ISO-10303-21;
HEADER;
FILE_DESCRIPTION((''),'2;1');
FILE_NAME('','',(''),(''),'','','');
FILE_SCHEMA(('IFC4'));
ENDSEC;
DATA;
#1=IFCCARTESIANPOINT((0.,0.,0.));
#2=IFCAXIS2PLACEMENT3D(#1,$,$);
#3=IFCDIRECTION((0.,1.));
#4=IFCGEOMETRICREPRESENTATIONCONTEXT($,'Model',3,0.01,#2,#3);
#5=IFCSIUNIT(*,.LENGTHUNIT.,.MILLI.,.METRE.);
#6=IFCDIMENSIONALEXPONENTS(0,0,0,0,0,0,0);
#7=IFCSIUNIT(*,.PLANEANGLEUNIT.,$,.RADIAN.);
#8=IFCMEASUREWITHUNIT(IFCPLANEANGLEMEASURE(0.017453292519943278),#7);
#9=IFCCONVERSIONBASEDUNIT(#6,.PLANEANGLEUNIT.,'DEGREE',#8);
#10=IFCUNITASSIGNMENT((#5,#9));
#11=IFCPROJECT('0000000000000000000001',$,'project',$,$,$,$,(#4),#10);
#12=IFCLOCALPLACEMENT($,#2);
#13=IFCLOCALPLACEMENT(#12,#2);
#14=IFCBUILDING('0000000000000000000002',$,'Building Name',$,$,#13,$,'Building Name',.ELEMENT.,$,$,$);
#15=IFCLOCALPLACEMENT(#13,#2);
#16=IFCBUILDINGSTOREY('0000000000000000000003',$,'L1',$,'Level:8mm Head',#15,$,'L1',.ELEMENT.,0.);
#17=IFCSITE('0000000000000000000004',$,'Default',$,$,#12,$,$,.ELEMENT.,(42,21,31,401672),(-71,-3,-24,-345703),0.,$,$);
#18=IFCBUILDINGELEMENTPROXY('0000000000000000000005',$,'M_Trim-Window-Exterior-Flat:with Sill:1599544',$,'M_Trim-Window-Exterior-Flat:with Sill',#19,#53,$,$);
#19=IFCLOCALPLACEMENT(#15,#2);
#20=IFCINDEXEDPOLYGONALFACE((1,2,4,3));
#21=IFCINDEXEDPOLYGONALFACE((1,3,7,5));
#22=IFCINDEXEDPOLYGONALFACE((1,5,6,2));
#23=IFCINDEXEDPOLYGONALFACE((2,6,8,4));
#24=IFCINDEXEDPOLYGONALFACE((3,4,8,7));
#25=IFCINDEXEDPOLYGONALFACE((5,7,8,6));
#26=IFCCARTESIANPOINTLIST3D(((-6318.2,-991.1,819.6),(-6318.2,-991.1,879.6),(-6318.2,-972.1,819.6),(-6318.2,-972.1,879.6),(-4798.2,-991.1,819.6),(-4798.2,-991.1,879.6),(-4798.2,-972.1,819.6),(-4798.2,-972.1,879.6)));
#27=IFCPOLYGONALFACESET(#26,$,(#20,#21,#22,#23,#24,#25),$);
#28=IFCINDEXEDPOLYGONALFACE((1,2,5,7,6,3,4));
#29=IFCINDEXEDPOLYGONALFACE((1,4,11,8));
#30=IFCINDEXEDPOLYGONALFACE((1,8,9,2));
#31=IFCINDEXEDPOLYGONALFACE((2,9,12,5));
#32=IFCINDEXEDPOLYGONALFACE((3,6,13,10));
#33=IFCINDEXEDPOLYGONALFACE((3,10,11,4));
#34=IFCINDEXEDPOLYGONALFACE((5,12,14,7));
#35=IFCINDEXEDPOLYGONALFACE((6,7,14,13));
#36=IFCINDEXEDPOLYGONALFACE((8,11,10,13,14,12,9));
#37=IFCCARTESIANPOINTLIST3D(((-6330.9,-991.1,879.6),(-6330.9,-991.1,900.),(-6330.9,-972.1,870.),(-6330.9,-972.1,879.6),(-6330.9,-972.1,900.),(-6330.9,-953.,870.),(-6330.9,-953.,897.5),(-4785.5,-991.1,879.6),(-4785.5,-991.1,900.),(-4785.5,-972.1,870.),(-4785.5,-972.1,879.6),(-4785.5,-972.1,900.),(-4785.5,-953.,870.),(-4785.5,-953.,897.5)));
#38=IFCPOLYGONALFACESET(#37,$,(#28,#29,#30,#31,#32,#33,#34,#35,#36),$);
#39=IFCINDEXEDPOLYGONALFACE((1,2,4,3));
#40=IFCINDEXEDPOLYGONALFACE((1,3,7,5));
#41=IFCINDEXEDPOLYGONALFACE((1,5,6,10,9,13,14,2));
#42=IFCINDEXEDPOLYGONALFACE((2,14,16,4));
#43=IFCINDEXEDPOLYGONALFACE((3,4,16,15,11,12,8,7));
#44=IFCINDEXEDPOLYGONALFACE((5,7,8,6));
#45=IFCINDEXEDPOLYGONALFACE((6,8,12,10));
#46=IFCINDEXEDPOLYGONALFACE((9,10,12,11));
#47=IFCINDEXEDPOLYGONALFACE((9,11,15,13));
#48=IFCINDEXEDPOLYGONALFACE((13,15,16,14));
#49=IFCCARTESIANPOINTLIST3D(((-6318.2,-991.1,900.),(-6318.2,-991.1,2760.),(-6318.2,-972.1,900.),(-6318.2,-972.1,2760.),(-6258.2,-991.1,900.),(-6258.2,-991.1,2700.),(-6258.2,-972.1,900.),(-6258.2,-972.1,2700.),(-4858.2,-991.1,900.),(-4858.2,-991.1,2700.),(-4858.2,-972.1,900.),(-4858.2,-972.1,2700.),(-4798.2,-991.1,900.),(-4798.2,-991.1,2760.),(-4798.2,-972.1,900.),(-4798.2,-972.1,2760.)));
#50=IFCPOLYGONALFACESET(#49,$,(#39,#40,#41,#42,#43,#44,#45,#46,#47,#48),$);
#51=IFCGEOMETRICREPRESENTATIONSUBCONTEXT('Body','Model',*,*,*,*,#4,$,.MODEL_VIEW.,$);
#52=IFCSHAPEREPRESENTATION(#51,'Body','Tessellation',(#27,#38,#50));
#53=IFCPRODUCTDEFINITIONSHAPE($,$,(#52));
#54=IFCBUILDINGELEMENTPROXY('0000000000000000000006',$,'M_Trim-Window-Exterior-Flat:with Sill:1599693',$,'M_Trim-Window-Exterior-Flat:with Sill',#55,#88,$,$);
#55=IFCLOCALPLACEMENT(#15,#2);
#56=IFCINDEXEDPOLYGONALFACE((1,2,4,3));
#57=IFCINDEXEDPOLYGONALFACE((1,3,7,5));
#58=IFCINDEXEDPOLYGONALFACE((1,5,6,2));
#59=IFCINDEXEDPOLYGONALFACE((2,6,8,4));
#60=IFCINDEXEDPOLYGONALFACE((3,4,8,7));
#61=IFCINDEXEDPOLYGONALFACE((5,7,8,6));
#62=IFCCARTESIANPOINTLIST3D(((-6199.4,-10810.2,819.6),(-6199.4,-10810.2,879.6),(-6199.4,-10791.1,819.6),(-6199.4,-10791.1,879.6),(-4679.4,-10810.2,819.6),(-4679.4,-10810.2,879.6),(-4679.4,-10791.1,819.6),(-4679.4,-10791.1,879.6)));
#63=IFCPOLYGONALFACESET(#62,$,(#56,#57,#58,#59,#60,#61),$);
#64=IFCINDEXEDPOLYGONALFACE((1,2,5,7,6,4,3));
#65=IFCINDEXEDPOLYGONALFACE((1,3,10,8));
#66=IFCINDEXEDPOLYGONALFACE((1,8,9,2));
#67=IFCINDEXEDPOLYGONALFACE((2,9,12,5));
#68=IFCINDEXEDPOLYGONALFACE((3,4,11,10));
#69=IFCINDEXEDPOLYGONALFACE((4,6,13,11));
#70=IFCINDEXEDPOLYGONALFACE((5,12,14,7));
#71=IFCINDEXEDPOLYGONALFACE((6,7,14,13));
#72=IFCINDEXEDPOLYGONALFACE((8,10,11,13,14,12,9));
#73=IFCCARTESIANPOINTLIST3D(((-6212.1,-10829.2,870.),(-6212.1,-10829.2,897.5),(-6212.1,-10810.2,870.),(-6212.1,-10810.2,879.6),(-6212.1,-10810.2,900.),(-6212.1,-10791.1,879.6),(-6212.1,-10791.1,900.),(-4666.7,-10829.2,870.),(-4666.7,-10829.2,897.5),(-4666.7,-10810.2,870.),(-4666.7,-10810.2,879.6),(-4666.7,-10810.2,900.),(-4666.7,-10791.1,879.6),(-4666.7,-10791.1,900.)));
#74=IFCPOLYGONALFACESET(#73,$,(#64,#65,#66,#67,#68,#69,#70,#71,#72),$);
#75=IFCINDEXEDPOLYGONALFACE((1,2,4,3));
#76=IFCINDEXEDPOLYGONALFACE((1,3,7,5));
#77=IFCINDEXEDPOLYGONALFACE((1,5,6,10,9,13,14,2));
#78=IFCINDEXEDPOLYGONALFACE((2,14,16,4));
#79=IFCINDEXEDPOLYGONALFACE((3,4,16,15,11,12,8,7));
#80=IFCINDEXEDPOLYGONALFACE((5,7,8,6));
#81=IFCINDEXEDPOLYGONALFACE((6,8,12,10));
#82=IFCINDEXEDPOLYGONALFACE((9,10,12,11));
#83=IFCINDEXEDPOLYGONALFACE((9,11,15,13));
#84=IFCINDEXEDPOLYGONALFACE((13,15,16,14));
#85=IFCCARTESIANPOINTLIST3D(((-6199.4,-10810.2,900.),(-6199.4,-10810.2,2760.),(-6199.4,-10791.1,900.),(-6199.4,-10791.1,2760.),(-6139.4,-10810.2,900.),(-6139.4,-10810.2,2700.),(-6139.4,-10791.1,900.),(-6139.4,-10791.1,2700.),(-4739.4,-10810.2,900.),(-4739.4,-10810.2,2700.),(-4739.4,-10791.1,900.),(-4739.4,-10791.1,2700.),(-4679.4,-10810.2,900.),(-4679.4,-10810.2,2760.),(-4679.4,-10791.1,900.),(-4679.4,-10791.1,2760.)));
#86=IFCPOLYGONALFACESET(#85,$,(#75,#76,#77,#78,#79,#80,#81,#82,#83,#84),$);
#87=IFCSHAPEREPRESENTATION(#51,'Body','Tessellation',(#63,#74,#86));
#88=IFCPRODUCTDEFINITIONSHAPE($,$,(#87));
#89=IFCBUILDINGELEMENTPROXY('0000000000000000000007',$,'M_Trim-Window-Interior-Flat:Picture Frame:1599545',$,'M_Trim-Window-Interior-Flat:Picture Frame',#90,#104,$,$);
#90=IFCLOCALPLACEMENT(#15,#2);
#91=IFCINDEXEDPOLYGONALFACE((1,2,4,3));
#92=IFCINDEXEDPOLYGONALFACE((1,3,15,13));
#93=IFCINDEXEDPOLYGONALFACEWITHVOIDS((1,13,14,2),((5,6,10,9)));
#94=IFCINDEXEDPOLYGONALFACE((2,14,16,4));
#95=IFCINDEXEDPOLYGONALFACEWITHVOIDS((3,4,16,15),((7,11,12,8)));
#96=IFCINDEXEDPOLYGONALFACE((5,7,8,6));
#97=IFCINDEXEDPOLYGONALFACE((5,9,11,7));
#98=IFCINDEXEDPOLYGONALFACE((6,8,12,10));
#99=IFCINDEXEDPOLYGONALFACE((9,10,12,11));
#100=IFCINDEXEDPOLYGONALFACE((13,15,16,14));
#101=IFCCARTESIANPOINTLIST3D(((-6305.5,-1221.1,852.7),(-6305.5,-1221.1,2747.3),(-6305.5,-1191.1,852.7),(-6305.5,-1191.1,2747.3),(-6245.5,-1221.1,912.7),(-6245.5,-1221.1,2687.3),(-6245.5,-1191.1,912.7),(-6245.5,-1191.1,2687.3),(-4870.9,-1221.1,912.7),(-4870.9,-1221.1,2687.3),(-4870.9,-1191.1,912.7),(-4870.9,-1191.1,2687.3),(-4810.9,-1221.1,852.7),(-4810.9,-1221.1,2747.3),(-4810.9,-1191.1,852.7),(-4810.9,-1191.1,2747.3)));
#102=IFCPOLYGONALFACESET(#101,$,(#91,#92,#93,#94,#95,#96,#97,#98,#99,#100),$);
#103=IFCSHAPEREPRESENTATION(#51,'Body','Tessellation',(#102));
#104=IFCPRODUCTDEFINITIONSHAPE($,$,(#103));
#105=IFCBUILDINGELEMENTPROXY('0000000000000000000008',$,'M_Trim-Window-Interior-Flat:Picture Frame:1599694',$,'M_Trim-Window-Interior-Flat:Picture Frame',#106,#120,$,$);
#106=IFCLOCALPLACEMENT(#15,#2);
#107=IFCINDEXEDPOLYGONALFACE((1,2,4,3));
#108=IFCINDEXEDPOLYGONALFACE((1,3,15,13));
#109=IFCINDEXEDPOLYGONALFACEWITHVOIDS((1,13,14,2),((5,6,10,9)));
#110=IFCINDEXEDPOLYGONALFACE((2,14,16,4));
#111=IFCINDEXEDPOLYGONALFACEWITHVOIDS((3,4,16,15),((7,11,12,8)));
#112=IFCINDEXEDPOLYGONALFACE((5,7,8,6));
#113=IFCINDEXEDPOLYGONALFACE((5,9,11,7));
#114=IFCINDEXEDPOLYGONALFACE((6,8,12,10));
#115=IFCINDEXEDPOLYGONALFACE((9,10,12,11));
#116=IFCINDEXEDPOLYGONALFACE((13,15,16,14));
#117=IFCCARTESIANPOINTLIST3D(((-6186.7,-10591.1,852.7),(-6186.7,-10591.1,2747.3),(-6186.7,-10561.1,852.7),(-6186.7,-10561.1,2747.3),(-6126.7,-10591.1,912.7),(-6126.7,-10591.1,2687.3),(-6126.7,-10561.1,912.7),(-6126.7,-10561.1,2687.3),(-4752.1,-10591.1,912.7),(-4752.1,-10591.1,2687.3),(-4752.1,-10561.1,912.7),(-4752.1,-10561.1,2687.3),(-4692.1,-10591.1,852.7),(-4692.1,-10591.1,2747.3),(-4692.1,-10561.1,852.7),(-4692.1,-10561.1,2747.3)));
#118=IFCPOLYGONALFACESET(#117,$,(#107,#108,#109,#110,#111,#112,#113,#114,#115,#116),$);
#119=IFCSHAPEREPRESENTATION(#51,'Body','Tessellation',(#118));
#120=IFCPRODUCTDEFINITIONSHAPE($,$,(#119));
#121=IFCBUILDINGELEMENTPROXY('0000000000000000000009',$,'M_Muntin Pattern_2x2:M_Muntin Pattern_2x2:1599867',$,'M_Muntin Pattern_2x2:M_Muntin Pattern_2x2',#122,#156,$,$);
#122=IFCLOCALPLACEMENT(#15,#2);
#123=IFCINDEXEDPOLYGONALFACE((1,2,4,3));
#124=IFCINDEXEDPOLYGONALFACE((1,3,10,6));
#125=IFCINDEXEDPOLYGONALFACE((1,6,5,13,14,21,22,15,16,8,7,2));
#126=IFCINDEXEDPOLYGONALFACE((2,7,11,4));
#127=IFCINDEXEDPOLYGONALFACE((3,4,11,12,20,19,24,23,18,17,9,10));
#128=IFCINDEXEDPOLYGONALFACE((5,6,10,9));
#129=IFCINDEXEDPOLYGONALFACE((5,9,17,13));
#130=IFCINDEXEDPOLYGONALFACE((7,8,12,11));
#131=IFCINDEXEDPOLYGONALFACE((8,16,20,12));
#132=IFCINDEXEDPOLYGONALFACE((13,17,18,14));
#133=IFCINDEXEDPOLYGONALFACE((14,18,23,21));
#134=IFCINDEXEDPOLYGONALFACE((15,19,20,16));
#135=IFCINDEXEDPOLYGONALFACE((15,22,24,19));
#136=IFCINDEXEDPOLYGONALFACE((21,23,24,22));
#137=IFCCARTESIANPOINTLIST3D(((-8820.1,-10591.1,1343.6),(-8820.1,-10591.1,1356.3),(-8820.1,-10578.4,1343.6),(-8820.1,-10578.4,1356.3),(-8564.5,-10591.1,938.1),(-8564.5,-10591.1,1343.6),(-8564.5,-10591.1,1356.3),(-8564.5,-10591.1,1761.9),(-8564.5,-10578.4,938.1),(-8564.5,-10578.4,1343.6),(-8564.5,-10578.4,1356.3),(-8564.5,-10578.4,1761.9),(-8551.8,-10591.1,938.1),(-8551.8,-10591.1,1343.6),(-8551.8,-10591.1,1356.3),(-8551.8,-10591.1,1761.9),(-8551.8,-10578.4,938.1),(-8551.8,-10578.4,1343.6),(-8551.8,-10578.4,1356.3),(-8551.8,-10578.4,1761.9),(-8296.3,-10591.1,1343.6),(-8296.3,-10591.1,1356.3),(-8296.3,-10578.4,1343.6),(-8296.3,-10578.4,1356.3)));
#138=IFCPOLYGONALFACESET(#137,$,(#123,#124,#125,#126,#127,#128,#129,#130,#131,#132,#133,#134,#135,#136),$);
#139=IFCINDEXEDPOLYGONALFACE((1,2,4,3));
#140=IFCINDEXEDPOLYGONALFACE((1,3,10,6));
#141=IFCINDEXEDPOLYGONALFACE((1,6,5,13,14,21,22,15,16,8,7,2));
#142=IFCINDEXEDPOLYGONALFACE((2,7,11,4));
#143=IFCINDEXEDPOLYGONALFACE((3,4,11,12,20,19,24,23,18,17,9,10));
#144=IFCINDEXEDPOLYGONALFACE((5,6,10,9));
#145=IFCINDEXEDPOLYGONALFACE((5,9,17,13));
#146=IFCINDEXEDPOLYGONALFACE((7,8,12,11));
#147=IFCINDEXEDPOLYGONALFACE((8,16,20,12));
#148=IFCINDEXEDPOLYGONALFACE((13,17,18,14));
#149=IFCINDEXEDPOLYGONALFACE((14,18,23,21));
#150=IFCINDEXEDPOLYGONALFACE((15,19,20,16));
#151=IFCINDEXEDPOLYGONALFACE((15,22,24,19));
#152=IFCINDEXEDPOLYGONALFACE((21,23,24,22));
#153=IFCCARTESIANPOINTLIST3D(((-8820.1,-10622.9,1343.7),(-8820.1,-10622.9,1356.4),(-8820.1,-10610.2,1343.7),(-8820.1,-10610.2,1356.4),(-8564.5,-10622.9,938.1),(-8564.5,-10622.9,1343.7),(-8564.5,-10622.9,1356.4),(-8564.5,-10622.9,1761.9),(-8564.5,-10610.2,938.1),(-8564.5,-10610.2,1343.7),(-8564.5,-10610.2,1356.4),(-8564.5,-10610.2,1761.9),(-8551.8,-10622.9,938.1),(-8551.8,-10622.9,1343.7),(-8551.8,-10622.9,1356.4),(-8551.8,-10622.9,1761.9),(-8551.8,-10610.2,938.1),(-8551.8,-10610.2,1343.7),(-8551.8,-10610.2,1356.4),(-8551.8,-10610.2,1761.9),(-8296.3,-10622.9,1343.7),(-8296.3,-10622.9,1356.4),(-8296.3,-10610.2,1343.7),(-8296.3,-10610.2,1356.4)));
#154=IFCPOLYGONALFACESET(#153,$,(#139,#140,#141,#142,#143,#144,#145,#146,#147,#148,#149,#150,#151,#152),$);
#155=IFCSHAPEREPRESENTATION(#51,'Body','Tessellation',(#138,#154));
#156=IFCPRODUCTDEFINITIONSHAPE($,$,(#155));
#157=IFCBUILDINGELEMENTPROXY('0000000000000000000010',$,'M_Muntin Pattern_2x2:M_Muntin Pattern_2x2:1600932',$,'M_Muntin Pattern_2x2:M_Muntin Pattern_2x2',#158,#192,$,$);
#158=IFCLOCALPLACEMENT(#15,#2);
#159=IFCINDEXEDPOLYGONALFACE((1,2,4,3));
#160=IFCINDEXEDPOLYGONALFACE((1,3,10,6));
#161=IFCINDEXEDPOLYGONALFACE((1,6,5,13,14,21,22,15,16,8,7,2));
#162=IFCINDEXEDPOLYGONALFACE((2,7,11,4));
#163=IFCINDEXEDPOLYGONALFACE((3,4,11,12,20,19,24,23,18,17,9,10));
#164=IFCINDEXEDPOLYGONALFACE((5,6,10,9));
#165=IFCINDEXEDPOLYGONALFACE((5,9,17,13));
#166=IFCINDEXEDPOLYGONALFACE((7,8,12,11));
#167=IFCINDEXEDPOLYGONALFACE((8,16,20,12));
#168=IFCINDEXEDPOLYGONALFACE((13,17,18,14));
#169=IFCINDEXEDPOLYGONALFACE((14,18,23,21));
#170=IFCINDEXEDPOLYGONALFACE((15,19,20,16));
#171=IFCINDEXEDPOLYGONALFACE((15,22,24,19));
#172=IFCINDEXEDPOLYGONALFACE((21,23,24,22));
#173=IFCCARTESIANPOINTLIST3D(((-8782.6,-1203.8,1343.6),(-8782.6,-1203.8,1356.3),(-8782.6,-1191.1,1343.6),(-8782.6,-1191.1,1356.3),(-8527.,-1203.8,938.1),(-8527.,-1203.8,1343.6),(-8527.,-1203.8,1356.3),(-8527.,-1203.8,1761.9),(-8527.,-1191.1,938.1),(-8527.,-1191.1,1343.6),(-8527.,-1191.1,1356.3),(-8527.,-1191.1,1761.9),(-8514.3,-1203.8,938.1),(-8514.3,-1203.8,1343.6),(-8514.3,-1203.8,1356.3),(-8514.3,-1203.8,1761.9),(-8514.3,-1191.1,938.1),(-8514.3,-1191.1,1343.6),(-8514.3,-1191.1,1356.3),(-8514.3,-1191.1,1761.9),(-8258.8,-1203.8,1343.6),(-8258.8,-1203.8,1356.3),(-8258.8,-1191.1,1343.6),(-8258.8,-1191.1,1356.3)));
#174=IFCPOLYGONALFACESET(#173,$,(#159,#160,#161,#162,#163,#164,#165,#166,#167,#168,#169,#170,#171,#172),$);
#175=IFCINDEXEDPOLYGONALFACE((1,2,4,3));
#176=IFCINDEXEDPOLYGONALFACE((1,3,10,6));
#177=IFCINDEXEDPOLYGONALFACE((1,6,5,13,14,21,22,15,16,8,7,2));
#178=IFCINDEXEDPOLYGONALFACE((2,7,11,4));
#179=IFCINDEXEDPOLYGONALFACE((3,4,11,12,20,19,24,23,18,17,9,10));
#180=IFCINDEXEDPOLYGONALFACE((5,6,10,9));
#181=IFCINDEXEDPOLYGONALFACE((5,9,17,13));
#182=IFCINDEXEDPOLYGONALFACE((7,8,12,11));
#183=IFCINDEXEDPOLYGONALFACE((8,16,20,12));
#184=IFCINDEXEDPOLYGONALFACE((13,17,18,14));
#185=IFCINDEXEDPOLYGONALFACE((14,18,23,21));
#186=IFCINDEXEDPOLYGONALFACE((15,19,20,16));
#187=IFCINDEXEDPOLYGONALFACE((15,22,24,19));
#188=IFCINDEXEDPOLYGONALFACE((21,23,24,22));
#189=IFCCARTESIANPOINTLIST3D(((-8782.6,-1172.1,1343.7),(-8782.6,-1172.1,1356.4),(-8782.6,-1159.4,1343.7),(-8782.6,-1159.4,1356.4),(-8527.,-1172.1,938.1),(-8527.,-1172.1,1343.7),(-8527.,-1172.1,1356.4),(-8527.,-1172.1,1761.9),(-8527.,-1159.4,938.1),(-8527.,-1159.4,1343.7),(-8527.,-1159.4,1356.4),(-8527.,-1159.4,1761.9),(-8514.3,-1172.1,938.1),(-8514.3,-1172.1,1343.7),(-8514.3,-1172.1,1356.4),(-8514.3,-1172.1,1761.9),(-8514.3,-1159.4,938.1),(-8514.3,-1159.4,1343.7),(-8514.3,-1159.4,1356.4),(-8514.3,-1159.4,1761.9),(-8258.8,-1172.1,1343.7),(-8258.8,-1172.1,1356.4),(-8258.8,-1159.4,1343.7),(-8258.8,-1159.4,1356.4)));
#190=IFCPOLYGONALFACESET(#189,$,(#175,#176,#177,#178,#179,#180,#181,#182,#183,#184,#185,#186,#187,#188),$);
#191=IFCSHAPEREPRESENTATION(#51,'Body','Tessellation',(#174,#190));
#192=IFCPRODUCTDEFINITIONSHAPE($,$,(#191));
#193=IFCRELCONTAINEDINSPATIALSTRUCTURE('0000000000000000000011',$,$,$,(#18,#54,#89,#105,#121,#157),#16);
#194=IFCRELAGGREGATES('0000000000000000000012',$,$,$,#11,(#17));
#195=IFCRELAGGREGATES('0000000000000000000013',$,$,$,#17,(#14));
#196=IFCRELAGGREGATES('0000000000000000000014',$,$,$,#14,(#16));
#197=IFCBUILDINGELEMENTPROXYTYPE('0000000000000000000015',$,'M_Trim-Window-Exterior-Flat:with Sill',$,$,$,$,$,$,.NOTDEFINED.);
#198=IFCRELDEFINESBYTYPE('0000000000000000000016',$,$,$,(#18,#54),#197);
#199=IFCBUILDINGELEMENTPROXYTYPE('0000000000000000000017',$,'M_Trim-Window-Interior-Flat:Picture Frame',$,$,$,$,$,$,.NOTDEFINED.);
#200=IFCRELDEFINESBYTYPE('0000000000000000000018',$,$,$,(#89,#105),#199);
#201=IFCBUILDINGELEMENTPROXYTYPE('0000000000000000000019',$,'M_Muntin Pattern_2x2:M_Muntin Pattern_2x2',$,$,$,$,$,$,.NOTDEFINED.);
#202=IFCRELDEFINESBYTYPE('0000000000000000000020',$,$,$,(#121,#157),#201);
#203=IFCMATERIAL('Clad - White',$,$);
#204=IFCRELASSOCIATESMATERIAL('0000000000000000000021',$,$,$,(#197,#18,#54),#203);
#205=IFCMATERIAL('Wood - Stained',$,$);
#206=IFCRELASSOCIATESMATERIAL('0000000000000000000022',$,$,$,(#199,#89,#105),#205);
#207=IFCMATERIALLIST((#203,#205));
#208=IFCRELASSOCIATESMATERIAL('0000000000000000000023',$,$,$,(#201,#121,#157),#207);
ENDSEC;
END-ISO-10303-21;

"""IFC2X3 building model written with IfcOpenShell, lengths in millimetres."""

from ifc_helpers import new_model, entity, si_unit, converted_unit, direction, frame, frame_2d, origin, place, context, subcontext, project, spatial, polyline, rectangle, outline, extrude, source, transform, mapped, material, material_list, type_object, type_shapes, element, save


model = new_model("IFC2X3")

# Units and contexts
model_context = context("Model", 3, precision=0.01, world=origin(), true_north=direction((0.0, 1.0)))
body_context = subcontext(model_context, "Body", "Model", "MODEL_VIEW")
ifc_project = project(units=[si_unit("LENGTHUNIT", "METRE", prefix="MILLI"), converted_unit("PLANEANGLEUNIT", "DEGREE", entity("IfcPlaneAngleMeasure", 0.017453292519943278), si_unit("PLANEANGLEUNIT", "RADIAN"), dimensions=[0, 0, 0, 0, 0, 0, 0])], contexts=[model_context])

# Site, building, storey
site_placement = place(None, origin())
site = spatial("IfcSite", under=ifc_project, at=site_placement, Name="Default", CompositionType="ELEMENT", RefLatitude=(42, 21, 31, 401672), RefLongitude=(-71, -3, -24, -345703), RefElevation=0.0)
building_placement = place(site_placement, origin())
building = spatial("IfcBuilding", under=site, at=building_placement, Name="Building Name", LongName="Building Name", CompositionType="ELEMENT")
storey_placement = place(building_placement, origin())
storey = spatial("IfcBuildingStorey", under=building, at=storey_placement, Name="L1", ObjectType="Level:8mm Head", LongName="L1", CompositionType="ELEMENT", Elevation=0.0)

# Building element proxies
ifc_material_1 = material(Name="Clad - White")
ifc_material_2 = material(Name="Wood - Stained")
ifc_material_list = material_list([ifc_material_1, ifc_material_2])
building_element_proxy_type_1 = type_object("IfcBuildingElementProxyType", Name="M_Trim-Window-Exterior-Flat:with Sill", PredefinedType="NOTDEFINED", material=ifc_material_1)
shared_shape_1 = source(origin(), body_context, "Body", "SweptSolid", [
    extrude(rectangle(XDim=1520.0, YDim=60.0, at=frame_2d((0.0, 0.0), x_axis=(1.0, 0.0))), frame((0.0, -1850.4, 0.0), z_axis=(0.0, 0.0, 1.0), x_axis=(-1.0, 0.0, 0.0)), (0.0, 0.0, 1.0), 19.0),
    extrude(outline(polyline([(-19.0, -15.2), (0.0, -15.2), (0.0, -5.7), (19.0, -5.7), (19.0, 14.8), (0.0, 14.8), (-19.0, 12.3), (-19.0, -15.2)])), frame((-772.7, -1814.8, 19.0), z_axis=(1.0, 0.0, 0.0), x_axis=(0.0, 0.0, -1.0)), (0.0, 0.0, 1.0), 1545.4),
    extrude(outline(polyline([(-945.0, -760.0), (915.0, -760.0), (915.0, -700.0), (-885.0, -700.0), (-885.0, 700.0), (915.0, 700.0), (915.0, 760.0), (-945.0, 760.0), (-945.0, -760.0)])), frame((0.0, -885.0, 0.0), z_axis=(0.0, 0.0, 1.0), x_axis=(0.0, -1.0, 0.0)), (0.0, 0.0, 1.0), 19.0),
])
type_shapes(building_element_proxy_type_1, [shared_shape_1])
for number, where, z_axis, x_axis, name in (
    (1, (-5558.2, -991.1, 2700.0), (0.0, 1.0, 0.0), (-1.0, 0.0, 0.0), "M_Trim-Window-Exterior-Flat:with Sill:1599544"),
    (2, (-5439.4, -10791.1, 2700.0), (0.0, -1.0, 0.0), (1.0, 0.0, 0.0), "M_Trim-Window-Exterior-Flat:with Sill:1599693"),
):
    element("IfcBuildingElementProxy", number, at=place(storey_placement, frame(where, z_axis=z_axis, x_axis=x_axis)), inside=storey, type_object=building_element_proxy_type_1, material=ifc_material_1, Name=name, ObjectType="M_Trim-Window-Exterior-Flat:with Sill", context=body_context, shape_type="MappedRepresentation", body=[
        mapped(shared_shape_1, transform((0.0, 0.0, 0.0), scale=1.0)),
    ])
building_element_proxy_type_2 = type_object("IfcBuildingElementProxyType", Name="M_Trim-Window-Interior-Flat:Picture Frame", PredefinedType="NOTDEFINED", material=ifc_material_2)
shared_shape_2 = source(origin(), body_context, "Body", "SweptSolid", [
    extrude(outline(polyline([(-747.3, -947.3), (747.3, -947.3), (747.3, 947.3), (-747.3, 947.3), (-747.3, -947.3)]), holes=[polyline([(-687.3, -887.3), (-687.3, 887.3), (687.3, 887.3), (687.3, -887.3), (-687.3, -887.3)])]), frame((0.0, -900.0, 0.0), z_axis=(0.0, 0.0, 1.0), x_axis=(-1.0, 0.0, 0.0)), (0.0, 0.0, 1.0), 30.0),
])
type_shapes(building_element_proxy_type_2, [shared_shape_2])
for number, where, z_axis, x_axis, name in (
    (3, (-5558.2, -1191.1, 2700.0), (0.0, -1.0, 0.0), (1.0, 0.0, 0.0), "M_Trim-Window-Interior-Flat:Picture Frame:1599545"),
    (4, (-5439.4, -10591.1, 2700.0), (0.0, 1.0, 0.0), (-1.0, 0.0, 0.0), "M_Trim-Window-Interior-Flat:Picture Frame:1599694"),
):
    element("IfcBuildingElementProxy", number, at=place(storey_placement, frame(where, z_axis=z_axis, x_axis=x_axis)), inside=storey, type_object=building_element_proxy_type_2, material=ifc_material_2, Name=name, ObjectType="M_Trim-Window-Interior-Flat:Picture Frame", context=body_context, shape_type="MappedRepresentation", body=[
        mapped(shared_shape_2, transform((0.0, 0.0, 0.0), scale=1.0)),
    ])
building_element_proxy_type_3 = type_object("IfcBuildingElementProxyType", Name="M_Muntin Pattern_2x2:M_Muntin Pattern_2x2", PredefinedType="NOTDEFINED", material=ifc_material_list)
shared_shape_3 = source(origin(), body_context, "Body", "SweptSolid", [
    extrude(outline(polyline([(6.4, -6.4), (411.9, -6.4), (411.9, 6.3), (6.4, 6.3), (6.4, 261.9), (-6.3, 261.9), (-6.3, 6.3), (-411.9, 6.3), (-411.9, -6.4), (-6.3, -6.4), (-6.3, -261.9), (6.4, -261.9), (6.4, -6.4)])), frame((0.0, -22.2, 411.9), z_axis=(0.0, 1.0, 0.0), x_axis=(0.0, 0.0, 1.0)), (0.0, 0.0, 1.0), 12.7),
    extrude(outline(polyline([(6.4, -6.4), (411.9, -6.4), (411.9, 6.3), (6.4, 6.3), (6.4, 261.9), (-6.3, 261.9), (-6.3, 6.3), (-411.9, 6.3), (-411.9, -6.4), (-6.3, -6.4), (-6.3, -261.9), (6.4, -261.9), (6.4, -6.4)])), frame((0.0, 9.5, 411.9), z_axis=(0.0, 1.0, 0.0), x_axis=(0.0, 0.0, 1.0)), (0.0, 0.0, 1.0), 12.7),
])
type_shapes(building_element_proxy_type_3, [shared_shape_3])
proxy_1_placement = place(storey_placement, frame((-8558.2, -10600.6, 938.1), z_axis=(0.0, 0.0, 1.0), x_axis=(-1.0, 0.0, 0.0)))
element("IfcBuildingElementProxy", 5, at=proxy_1_placement, inside=storey, type_object=building_element_proxy_type_3, material=ifc_material_list, Name="M_Muntin Pattern_2x2:M_Muntin Pattern_2x2:1599867", ObjectType="M_Muntin Pattern_2x2:M_Muntin Pattern_2x2", context=body_context, shape_type="MappedRepresentation", body=[
    mapped(shared_shape_3, transform((0.0, 0.0, 0.0), scale=1.0)),
])
proxy_2_placement = place(storey_placement, frame((-8520.7, -1181.6, 938.1)))
element("IfcBuildingElementProxy", 6, at=proxy_2_placement, inside=storey, type_object=building_element_proxy_type_3, material=ifc_material_list, Name="M_Muntin Pattern_2x2:M_Muntin Pattern_2x2:1600932", ObjectType="M_Muntin Pattern_2x2:M_Muntin Pattern_2x2", context=body_context, shape_type="MappedRepresentation", body=[
    mapped(shared_shape_3, transform((0.0, 0.0, 0.0), scale=1.0)),
])

save(model, "model.ifc")
